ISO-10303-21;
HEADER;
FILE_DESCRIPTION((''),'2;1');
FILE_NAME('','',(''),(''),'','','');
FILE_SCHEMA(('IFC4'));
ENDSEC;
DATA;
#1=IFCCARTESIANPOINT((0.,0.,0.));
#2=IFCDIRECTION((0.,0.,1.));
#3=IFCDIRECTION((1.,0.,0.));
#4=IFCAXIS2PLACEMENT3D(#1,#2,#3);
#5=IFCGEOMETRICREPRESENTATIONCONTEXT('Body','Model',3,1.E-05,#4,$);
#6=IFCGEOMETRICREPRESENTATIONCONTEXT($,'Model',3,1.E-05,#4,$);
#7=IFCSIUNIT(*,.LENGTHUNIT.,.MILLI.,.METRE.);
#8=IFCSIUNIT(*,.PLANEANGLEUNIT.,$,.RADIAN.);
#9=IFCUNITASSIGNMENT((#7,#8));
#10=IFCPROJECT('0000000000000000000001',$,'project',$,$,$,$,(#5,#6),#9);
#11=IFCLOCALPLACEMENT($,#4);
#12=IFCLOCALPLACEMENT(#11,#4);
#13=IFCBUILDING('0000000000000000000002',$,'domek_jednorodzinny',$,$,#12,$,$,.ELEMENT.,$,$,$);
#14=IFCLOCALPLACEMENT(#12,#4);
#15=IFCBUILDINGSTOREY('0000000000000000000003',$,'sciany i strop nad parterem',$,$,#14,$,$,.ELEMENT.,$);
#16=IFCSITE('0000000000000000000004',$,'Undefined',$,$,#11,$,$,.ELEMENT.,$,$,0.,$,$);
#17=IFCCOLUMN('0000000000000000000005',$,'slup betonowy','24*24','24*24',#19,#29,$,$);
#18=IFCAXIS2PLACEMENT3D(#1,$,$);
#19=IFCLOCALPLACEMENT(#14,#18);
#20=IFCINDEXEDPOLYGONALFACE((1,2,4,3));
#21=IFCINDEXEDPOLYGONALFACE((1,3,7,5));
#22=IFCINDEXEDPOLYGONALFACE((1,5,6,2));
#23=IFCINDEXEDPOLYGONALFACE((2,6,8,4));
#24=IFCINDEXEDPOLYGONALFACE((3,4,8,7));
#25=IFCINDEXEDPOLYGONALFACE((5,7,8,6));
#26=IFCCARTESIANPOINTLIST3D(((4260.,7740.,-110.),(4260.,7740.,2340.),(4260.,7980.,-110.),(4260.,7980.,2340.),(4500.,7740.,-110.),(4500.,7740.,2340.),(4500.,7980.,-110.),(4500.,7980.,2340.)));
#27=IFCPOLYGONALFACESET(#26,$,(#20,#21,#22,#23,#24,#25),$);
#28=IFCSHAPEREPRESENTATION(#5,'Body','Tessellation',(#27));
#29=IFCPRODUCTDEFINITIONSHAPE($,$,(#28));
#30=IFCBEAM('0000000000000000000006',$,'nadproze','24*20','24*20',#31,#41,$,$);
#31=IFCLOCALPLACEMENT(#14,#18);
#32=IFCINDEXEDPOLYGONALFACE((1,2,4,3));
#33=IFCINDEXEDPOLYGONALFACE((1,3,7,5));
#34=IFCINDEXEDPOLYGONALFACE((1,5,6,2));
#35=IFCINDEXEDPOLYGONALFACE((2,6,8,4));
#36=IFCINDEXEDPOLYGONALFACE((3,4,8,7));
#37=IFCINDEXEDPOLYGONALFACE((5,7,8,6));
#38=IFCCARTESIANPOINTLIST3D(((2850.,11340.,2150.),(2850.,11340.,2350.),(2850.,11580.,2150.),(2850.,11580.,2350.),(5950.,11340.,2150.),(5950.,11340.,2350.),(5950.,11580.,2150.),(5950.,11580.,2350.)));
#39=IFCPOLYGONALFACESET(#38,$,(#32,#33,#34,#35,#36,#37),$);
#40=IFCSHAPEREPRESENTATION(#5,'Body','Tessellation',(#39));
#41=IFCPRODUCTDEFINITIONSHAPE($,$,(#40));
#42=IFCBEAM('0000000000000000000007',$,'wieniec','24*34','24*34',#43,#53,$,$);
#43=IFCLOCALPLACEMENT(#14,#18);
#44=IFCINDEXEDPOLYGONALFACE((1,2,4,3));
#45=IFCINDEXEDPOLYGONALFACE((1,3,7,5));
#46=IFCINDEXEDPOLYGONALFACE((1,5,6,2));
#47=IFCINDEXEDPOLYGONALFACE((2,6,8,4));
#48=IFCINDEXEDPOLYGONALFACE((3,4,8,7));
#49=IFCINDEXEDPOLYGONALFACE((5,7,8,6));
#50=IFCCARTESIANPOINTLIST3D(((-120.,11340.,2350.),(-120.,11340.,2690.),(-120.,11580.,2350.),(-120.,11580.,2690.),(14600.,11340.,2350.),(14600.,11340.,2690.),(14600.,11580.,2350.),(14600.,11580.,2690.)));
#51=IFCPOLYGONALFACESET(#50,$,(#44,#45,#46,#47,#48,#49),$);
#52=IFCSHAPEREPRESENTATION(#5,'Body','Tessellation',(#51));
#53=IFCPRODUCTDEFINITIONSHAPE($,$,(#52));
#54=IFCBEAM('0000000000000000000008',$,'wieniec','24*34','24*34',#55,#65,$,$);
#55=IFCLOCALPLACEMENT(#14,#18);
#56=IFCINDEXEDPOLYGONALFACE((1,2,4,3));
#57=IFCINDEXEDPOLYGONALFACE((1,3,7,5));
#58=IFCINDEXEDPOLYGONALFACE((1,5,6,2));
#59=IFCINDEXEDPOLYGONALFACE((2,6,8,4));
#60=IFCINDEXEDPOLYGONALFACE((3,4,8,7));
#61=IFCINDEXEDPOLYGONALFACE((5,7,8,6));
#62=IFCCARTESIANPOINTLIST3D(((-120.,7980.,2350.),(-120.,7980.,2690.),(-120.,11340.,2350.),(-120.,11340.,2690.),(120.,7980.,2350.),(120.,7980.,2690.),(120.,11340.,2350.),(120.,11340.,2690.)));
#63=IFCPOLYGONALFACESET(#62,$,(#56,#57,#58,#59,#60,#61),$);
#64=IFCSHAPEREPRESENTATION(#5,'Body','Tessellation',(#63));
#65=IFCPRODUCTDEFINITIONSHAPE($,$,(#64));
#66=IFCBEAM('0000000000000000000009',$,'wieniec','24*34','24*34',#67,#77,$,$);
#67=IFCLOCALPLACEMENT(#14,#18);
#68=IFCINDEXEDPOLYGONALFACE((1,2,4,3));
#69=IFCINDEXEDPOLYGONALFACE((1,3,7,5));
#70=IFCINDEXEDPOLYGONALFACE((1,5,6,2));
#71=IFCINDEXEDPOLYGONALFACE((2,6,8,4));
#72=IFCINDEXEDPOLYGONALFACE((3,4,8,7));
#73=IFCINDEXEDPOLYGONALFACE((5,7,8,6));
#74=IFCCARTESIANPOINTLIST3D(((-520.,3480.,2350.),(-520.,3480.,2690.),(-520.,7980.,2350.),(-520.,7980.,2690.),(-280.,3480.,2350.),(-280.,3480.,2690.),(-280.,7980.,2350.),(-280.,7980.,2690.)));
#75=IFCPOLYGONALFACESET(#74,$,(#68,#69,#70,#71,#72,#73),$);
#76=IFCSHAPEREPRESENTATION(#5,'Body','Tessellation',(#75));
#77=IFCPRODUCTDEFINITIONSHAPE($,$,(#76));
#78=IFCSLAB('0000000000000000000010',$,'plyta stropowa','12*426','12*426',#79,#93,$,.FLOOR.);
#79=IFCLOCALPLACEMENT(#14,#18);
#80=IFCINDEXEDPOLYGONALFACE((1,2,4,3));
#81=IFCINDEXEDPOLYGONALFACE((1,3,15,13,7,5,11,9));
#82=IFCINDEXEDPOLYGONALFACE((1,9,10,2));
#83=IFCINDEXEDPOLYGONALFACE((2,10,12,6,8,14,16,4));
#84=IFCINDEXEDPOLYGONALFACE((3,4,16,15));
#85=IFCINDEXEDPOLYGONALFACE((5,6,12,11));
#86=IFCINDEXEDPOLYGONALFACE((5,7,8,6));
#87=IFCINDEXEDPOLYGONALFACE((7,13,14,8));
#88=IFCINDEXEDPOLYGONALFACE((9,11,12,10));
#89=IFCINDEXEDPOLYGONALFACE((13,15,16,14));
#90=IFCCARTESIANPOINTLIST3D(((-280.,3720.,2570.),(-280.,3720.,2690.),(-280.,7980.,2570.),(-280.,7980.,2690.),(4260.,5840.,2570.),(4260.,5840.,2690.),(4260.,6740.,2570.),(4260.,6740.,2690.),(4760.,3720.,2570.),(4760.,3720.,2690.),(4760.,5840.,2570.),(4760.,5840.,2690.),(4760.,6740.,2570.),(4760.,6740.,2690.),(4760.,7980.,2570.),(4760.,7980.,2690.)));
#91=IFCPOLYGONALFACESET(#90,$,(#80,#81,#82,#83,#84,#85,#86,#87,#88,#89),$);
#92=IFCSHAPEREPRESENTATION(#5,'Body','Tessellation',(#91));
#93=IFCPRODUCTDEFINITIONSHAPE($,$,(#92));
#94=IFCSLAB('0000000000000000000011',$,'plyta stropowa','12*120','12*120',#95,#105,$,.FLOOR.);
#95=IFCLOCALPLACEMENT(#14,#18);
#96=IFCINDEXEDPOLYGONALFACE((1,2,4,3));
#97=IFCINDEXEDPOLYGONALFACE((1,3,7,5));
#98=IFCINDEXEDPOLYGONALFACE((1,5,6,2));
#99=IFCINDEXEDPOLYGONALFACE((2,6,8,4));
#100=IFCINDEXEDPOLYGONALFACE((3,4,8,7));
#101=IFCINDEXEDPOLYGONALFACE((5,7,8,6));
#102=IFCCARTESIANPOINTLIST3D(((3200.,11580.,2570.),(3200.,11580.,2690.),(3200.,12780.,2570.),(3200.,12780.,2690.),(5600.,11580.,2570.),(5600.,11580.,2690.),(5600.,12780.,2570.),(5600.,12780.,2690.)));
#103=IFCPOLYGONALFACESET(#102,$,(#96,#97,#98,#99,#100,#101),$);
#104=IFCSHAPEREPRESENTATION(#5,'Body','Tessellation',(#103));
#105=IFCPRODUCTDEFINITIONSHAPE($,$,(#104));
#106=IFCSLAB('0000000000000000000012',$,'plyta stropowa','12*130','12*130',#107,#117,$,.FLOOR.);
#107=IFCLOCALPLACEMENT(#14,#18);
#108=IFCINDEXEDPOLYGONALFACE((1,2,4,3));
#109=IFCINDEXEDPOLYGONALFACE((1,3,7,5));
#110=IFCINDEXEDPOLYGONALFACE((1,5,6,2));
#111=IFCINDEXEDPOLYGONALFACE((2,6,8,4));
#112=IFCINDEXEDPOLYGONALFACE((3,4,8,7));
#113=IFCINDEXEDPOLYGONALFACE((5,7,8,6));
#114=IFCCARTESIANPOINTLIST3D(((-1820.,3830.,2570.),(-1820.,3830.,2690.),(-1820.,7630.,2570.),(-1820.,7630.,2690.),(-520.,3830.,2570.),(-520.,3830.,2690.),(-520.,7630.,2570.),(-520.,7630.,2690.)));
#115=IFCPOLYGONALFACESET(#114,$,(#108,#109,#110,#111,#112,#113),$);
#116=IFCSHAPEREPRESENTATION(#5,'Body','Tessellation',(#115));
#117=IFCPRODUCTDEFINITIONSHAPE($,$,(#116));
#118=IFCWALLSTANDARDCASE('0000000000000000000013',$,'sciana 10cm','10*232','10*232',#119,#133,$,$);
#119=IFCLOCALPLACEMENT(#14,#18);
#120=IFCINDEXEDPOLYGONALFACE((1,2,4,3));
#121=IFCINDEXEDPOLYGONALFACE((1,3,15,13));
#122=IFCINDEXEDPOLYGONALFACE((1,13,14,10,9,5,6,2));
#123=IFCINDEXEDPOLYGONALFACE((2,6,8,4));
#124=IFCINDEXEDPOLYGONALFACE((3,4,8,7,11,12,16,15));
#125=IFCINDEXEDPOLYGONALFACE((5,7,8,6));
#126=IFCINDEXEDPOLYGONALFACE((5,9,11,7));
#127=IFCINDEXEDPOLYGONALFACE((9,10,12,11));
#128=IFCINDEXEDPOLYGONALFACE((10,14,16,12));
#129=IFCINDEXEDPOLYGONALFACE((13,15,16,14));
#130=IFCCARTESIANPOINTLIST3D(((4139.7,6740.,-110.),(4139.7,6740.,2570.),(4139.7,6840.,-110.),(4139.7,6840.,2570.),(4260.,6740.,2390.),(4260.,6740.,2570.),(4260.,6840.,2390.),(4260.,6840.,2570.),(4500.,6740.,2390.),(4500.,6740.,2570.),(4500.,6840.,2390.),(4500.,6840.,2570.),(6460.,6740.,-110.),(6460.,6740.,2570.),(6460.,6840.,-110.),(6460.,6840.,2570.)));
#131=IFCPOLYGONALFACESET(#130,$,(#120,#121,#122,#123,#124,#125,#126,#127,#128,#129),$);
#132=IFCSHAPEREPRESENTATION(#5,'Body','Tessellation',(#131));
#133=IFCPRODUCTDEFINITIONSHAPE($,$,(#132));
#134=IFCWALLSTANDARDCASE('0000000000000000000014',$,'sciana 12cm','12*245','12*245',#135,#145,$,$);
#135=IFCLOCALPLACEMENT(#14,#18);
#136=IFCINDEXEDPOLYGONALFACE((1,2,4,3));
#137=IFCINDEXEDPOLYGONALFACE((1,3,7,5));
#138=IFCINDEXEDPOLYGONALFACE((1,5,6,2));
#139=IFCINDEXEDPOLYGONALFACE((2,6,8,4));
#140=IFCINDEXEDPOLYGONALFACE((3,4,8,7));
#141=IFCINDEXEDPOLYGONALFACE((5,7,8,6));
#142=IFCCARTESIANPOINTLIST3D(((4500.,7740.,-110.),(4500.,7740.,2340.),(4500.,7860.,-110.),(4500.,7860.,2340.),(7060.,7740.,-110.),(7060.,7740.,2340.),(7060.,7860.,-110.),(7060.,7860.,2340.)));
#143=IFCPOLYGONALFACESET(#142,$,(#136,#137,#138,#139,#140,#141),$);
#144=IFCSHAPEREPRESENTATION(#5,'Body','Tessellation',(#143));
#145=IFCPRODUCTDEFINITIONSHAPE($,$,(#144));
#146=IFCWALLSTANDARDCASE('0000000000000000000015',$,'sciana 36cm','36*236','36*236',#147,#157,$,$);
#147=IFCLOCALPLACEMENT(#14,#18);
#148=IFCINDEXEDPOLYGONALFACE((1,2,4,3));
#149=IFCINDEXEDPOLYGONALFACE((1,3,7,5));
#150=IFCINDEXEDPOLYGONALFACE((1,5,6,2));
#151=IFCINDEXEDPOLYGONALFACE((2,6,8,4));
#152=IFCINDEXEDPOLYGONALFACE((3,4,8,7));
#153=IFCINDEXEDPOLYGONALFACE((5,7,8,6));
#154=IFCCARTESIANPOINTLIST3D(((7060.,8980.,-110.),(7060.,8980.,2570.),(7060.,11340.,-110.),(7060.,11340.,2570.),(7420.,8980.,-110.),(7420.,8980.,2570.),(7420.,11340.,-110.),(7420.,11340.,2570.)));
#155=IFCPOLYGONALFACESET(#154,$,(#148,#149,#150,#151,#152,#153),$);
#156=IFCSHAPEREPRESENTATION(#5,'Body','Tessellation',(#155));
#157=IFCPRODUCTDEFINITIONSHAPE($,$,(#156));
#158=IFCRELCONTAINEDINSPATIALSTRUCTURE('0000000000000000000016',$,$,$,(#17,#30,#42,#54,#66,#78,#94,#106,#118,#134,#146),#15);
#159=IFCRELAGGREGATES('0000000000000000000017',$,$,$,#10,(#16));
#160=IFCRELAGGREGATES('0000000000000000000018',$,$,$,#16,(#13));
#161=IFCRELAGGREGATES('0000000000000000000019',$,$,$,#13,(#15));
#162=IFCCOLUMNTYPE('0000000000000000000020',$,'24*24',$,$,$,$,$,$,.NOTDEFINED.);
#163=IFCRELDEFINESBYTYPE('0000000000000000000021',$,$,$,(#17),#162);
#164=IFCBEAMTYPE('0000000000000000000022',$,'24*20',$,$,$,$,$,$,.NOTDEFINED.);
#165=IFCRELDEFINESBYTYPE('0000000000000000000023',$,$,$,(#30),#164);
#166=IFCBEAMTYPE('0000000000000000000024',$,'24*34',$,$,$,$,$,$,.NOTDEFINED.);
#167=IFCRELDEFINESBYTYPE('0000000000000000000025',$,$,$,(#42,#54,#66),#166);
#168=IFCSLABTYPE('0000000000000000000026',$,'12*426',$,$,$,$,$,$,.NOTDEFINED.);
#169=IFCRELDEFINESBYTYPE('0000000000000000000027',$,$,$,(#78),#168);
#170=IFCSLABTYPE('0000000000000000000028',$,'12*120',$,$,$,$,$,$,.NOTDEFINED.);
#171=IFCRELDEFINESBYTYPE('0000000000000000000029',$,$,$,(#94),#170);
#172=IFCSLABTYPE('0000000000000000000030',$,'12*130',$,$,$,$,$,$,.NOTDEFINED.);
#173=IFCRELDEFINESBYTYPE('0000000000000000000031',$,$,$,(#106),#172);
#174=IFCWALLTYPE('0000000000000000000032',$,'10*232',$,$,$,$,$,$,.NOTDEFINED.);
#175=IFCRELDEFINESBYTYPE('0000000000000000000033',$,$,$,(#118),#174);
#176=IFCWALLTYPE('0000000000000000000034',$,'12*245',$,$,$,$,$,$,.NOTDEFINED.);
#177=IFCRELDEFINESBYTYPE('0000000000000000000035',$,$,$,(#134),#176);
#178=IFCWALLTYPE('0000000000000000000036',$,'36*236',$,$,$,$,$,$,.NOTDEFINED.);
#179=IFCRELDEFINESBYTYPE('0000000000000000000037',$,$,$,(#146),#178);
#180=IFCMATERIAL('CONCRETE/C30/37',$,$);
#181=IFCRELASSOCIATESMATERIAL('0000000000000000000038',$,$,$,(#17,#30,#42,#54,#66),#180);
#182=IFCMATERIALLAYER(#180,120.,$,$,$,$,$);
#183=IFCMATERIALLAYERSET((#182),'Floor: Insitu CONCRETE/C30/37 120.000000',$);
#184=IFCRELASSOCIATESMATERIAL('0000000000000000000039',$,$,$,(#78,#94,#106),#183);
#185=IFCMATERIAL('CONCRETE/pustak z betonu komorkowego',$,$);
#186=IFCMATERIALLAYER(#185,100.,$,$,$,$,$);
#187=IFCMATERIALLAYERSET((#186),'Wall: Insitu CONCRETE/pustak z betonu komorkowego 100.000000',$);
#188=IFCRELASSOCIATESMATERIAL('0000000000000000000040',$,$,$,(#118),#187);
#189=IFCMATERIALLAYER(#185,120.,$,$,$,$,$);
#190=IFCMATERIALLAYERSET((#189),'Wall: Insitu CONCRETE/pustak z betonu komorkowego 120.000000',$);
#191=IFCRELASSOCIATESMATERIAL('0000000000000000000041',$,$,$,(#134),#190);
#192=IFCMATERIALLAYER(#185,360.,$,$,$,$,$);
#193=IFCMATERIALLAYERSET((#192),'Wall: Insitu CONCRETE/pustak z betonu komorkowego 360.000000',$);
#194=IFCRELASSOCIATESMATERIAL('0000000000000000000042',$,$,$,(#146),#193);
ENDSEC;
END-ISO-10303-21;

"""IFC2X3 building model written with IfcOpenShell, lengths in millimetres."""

from ifc_helpers import new_model, si_unit, frame, frame_2d, origin_with_axes, origin_2d_with_axis, place, context, project, spatial, polyline, rectangle, outline, extrude, material, layer, layer_set, layer_usage, type_object, element, save


model = new_model("IFC2X3")

# Units and contexts
model_context_1 = context("Model", 3, precision=1e-05, world=origin_with_axes(), identifier="Body")
model_context_2 = context("Model", 3, precision=1e-05, world=origin_with_axes())
ifc_project = project(units=[si_unit("LENGTHUNIT", "METRE", prefix="MILLI"), si_unit("PLANEANGLEUNIT", "RADIAN")], contexts=[model_context_1, model_context_2])

# Site, building, storey
site_placement = place(None, origin_with_axes())
site = spatial("IfcSite", under=ifc_project, at=site_placement, Name="Undefined", CompositionType="ELEMENT", RefElevation=0.0)
building_placement = place(site_placement, origin_with_axes())
building = spatial("IfcBuilding", under=site, at=building_placement, Name="domek_jednorodzinny", CompositionType="ELEMENT")
storey_placement = place(building_placement, origin_with_axes())
storey = spatial("IfcBuildingStorey", under=building, at=storey_placement, Name="sciany i strop nad parterem", CompositionType="ELEMENT")

# Column
ifc_material_1 = material(Name="CONCRETE/C30/37")
column_type = type_object("IfcColumnType", Name="24*24", PredefinedType="NOTDEFINED")
column_placement = place(storey_placement, frame((4380.0, 7860.0, -110.0), z_axis=(0.0, 0.0, 1.0), x_axis=(1.0, 0.0, 0.0)))
element("IfcColumn", 1, at=column_placement, inside=storey, type_object=column_type, material=ifc_material_1, Name="slup betonowy", Description="24*24", ObjectType="24*24", context=model_context_1, shape_type="SweptSolid", body=[
    extrude(rectangle(XDim=240.0, YDim=240.0, at=origin_2d_with_axis()), frame((0.0, 0.0, 2450.0), z_axis=(0.000001, 0.000001, -1.0), x_axis=(-1.0, 0.0, 0.0)), (0.0, 0.0, 1.0), 2450.0),
])

# Beams
beam_type_1 = type_object("IfcBeamType", Name="24*20", PredefinedType="NOTDEFINED")
beam_1_placement = place(storey_placement, frame((2850.0, 11460.0, 2250.0), z_axis=(0.0, 0.0, 1.0), x_axis=(1.0, 0.0, 0.0)))
element("IfcBeam", 2, at=beam_1_placement, inside=storey, type_object=beam_type_1, material=ifc_material_1, Name="nadproze", Description="24*20", ObjectType="24*20", context=model_context_1, shape_type="SweptSolid", body=[
    extrude(rectangle(XDim=240.0, YDim=200.0, at=origin_2d_with_axis()), frame((3100.0, 0.0, 0.0), z_axis=(-1.0, 0.0, 0.0), x_axis=(0.0, -1.0, 0.0)), (0.0, 0.0, 1.0), 3100.0),
])
beam_type_2 = type_object("IfcBeamType", Name="24*34", PredefinedType="NOTDEFINED")
beam_2_placement = place(storey_placement, frame((-120.0, 11460.0, 2520.0), z_axis=(0.0, 0.0, 1.0), x_axis=(1.0, 0.0, 0.0)))
element("IfcBeam", 3, at=beam_2_placement, inside=storey, type_object=beam_type_2, material=ifc_material_1, Name="wieniec", Description="24*34", ObjectType="24*34", context=model_context_1, shape_type="SweptSolid", body=[
    extrude(rectangle(XDim=240.0, YDim=340.0, at=origin_2d_with_axis()), frame((14720.0, 0.0, 0.0), z_axis=(-1.0, 0.0, 0.0), x_axis=(0.0, -1.0, 0.0)), (0.0, 0.0, 1.0), 14720.0),
])
beam_3_placement = place(storey_placement, frame((0.0, 11340.0, 2520.0), z_axis=(0.0, 0.0, 1.0), x_axis=(0.0, -1.0, 0.0)))
element("IfcBeam", 4, at=beam_3_placement, inside=storey, type_object=beam_type_2, material=ifc_material_1, Name="wieniec", Description="24*34", ObjectType="24*34", context=model_context_1, shape_type="SweptSolid", body=[
    extrude(rectangle(XDim=240.0, YDim=340.0, at=origin_2d_with_axis()), frame((3360.0, 0.0, 0.0), z_axis=(-1.0, 0.0, 0.0), x_axis=(0.0, -1.0, 0.0)), (0.0, 0.0, 1.0), 3360.0),
])
beam_4_placement = place(storey_placement, frame((-400.0, 7980.0, 2520.0), z_axis=(0.0, 0.0, 1.0), x_axis=(0.0, -1.0, 0.0)))
element("IfcBeam", 5, at=beam_4_placement, inside=storey, type_object=beam_type_2, material=ifc_material_1, Name="wieniec", Description="24*34", ObjectType="24*34", context=model_context_1, shape_type="SweptSolid", body=[
    extrude(rectangle(XDim=240.0, YDim=340.0, at=origin_2d_with_axis()), frame((4500.0, 0.0, 0.0), z_axis=(-1.0, 0.0, 0.0), x_axis=(0.0, -1.0, 0.0)), (0.0, 0.0, 1.0), 4500.0),
])

# Slab, opening
ifc_layer_1 = layer(ifc_material_1, 120.0)
ifc_layer_set_1 = layer_set([ifc_layer_1], Name="Floor: Insitu CONCRETE/C30/37 120.000000")
ifc_layer_usage_1 = layer_usage(ifc_layer_set_1, "AXIS3", "POSITIVE", -60.0)
slab_type_1 = type_object("IfcSlabType", Name="12*426", PredefinedType="NOTDEFINED")
slab_1_placement = place(storey_placement, frame((4760.0, 7980.0, 2630.0), z_axis=(0.0, 0.0, 1.0), x_axis=(-1.0, 0.0, 0.0)))
slab_1 = element("IfcSlab", 6, at=slab_1_placement, inside=storey, type_object=slab_type_1, material=ifc_layer_usage_1, Name="plyta stropowa", Description="12*426", ObjectType="12*426", PredefinedType="FLOOR", context=model_context_1, shape_type="SweptSolid", body=[
    extrude(outline(polyline([(0.0, 0.0), (5040.0, 0.0), (5040.0, 4260.0), (0.0, 4260.0), (0.0, 0.0)])), frame((0.0, 0.0, -60.0), z_axis=(0.0, 0.0, 1.0), x_axis=(1.0, 0.0, 0.0)), (0.0, 0.0, 1.0), 120.0),
])
opening_1_placement = place(storey_placement, frame((4760.0, 7980.0, 2630.0), z_axis=(0.0, 0.0, 1.0), x_axis=(-1.0, 0.0, 0.0)))
element("IfcOpeningElement", 7, at=opening_1_placement, cuts=slab_1, ObjectType="Recess", context=model_context_1, shape_type="SweptSolid", body=[
    extrude(outline(polyline([(0.0, 0.0), (500.0, 0.0), (500.0, 900.0), (0.0, 900.0), (0.0, 0.0)])), frame((500.0, 2140.0, -112.5), z_axis=(0.0, 0.0, 1.0), x_axis=(-1.0, 0.0, 0.0)), (0.0, 0.0, 1.0), 225.0),
])

# Slabs
ifc_layer_usage_2 = layer_usage(ifc_layer_set_1, "AXIS3", "POSITIVE", -60.0)
slab_type_2 = type_object("IfcSlabType", Name="12*120", PredefinedType="NOTDEFINED")
slab_2_placement = place(storey_placement, frame((5600.0, 12780.0, 2630.0), z_axis=(0.0, 0.0, 1.0), x_axis=(-1.0, 0.0, 0.0)))
element("IfcSlab", 8, at=slab_2_placement, inside=storey, type_object=slab_type_2, material=ifc_layer_usage_2, Name="plyta stropowa", Description="12*120", ObjectType="12*120", PredefinedType="FLOOR", context=model_context_1, shape_type="SweptSolid", body=[
    extrude(outline(polyline([(0.0, 0.0), (2400.0, 0.0), (2400.0, 1200.0), (0.0, 1200.0), (0.0, 0.0)])), frame((0.0, 0.0, -60.0), z_axis=(0.0, 0.0, 1.0), x_axis=(1.0, 0.0, 0.0)), (0.0, 0.0, 1.0), 120.0),
])
ifc_layer_usage_3 = layer_usage(ifc_layer_set_1, "AXIS3", "POSITIVE", -60.0)
slab_type_3 = type_object("IfcSlabType", Name="12*130", PredefinedType="NOTDEFINED")
slab_3_placement = place(storey_placement, frame((-520.0, 7630.0, 2630.0), z_axis=(0.0, 0.0, 1.0), x_axis=(-1.0, 0.0, 0.0)))
element("IfcSlab", 9, at=slab_3_placement, inside=storey, type_object=slab_type_3, material=ifc_layer_usage_3, Name="plyta stropowa", Description="12*130", ObjectType="12*130", PredefinedType="FLOOR", context=model_context_1, shape_type="SweptSolid", body=[
    extrude(outline(polyline([(0.0, 0.0), (1300.0, 0.0), (1300.0, 3800.0), (0.0, 3800.0), (0.0, 0.0)])), frame((0.0, 0.0, -60.0), z_axis=(0.0, 0.0, 1.0), x_axis=(1.0, 0.0, 0.0)), (0.0, 0.0, 1.0), 120.0),
])

# Wall, opening
ifc_material_2 = material(Name="CONCRETE/pustak z betonu komorkowego")
ifc_layer_2 = layer(ifc_material_2, 100.0)
ifc_layer_set_2 = layer_set([ifc_layer_2], Name="Wall: Insitu CONCRETE/pustak z betonu komorkowego 100.000000")
ifc_layer_usage_4 = layer_usage(ifc_layer_set_2, "AXIS2", "POSITIVE", -50.0)
wall_type_1 = type_object("IfcWallType", Name="10*232", PredefinedType="NOTDEFINED")
wall_1_placement = place(storey_placement, frame((4139.7, 6790.0, -110.0), z_axis=(0.0, 0.0, 1.0), x_axis=(1.0, 0.0, 0.0)))
wall_1 = element("IfcWallStandardCase", 10, at=wall_1_placement, inside=storey, type_object=wall_type_1, material=ifc_layer_usage_4, Name="sciana 10cm", Description="10*232", ObjectType="10*232", context=model_context_1, shape_type="SweptSolid", body=[
    extrude(rectangle(XDim=2320.3, YDim=100.0, at=frame_2d((0.0, 1160.1), x_axis=(0.0, -1.0))), frame((0.0, 0.0, 0.0), z_axis=(0.0, 0.0, 1.0), x_axis=(0.0, -1.0, 0.0)), (0.0, 0.0, 1.0), 2680.0),
])
opening_2_placement = place(storey_placement, frame((4139.7, 6790.0, -110.0), z_axis=(0.0, 0.0, 1.0), x_axis=(1.0, 0.0, 0.0)))
element("IfcOpeningElement", 11, at=opening_2_placement, cuts=wall_1, ObjectType="Recess", context=model_context_1, shape_type="SweptSolid", body=[
    extrude(outline(polyline([(0.0, 0.0), (180.0, 0.0), (180.0, 240.0), (0.0, 240.0), (0.0, 0.0)])), frame((360.3, -52.5, 2680.0), z_axis=(0.0, 1.0, 0.0), x_axis=(0.000001, 0.000001, -1.0)), (0.0, 0.0, 1.0), 105.0),
])

# Walls
ifc_layer_3 = layer(ifc_material_2, 120.0)
ifc_layer_set_3 = layer_set([ifc_layer_3], Name="Wall: Insitu CONCRETE/pustak z betonu komorkowego 120.000000")
ifc_layer_usage_5 = layer_usage(ifc_layer_set_3, "AXIS2", "POSITIVE", -60.0)
wall_type_2 = type_object("IfcWallType", Name="12*245", PredefinedType="NOTDEFINED")
wall_2_placement = place(storey_placement, frame((4500.0, 7800.0, -110.0), z_axis=(0.0, 0.0, 1.0), x_axis=(1.0, 0.0, 0.0)))
element("IfcWallStandardCase", 12, at=wall_2_placement, inside=storey, type_object=wall_type_2, material=ifc_layer_usage_5, Name="sciana 12cm", Description="12*245", ObjectType="12*245", context=model_context_1, shape_type="SweptSolid", body=[
    extrude(rectangle(XDim=2560.0, YDim=120.0, at=frame_2d((0.0, 1280.0), x_axis=(0.0, -1.0))), frame((0.0, 0.0, 0.0), z_axis=(0.0, 0.0, 1.0), x_axis=(0.0, -1.0, 0.0)), (0.0, 0.0, 1.0), 2450.0),
])
ifc_layer_4 = layer(ifc_material_2, 360.0)
ifc_layer_set_4 = layer_set([ifc_layer_4], Name="Wall: Insitu CONCRETE/pustak z betonu komorkowego 360.000000")
ifc_layer_usage_6 = layer_usage(ifc_layer_set_4, "AXIS2", "POSITIVE", -180.0)
wall_type_3 = type_object("IfcWallType", Name="36*236", PredefinedType="NOTDEFINED")
wall_3_placement = place(storey_placement, frame((7240.0, 8980.0, -110.0), z_axis=(0.0, 0.0, 1.0), x_axis=(0.0, 1.0, 0.0)))
element("IfcWallStandardCase", 13, at=wall_3_placement, inside=storey, type_object=wall_type_3, material=ifc_layer_usage_6, Name="sciana 36cm", Description="36*236", ObjectType="36*236", context=model_context_1, shape_type="SweptSolid", body=[
    extrude(rectangle(XDim=2360.0, YDim=360.0, at=frame_2d((0.0, 1180.0), x_axis=(0.0, -1.0))), frame((0.0, 0.0, 0.0), z_axis=(0.0, 0.0, 1.0), x_axis=(0.0, -1.0, 0.0)), (0.0, 0.0, 1.0), 2680.0),
])

save(model, "model.ifc")
